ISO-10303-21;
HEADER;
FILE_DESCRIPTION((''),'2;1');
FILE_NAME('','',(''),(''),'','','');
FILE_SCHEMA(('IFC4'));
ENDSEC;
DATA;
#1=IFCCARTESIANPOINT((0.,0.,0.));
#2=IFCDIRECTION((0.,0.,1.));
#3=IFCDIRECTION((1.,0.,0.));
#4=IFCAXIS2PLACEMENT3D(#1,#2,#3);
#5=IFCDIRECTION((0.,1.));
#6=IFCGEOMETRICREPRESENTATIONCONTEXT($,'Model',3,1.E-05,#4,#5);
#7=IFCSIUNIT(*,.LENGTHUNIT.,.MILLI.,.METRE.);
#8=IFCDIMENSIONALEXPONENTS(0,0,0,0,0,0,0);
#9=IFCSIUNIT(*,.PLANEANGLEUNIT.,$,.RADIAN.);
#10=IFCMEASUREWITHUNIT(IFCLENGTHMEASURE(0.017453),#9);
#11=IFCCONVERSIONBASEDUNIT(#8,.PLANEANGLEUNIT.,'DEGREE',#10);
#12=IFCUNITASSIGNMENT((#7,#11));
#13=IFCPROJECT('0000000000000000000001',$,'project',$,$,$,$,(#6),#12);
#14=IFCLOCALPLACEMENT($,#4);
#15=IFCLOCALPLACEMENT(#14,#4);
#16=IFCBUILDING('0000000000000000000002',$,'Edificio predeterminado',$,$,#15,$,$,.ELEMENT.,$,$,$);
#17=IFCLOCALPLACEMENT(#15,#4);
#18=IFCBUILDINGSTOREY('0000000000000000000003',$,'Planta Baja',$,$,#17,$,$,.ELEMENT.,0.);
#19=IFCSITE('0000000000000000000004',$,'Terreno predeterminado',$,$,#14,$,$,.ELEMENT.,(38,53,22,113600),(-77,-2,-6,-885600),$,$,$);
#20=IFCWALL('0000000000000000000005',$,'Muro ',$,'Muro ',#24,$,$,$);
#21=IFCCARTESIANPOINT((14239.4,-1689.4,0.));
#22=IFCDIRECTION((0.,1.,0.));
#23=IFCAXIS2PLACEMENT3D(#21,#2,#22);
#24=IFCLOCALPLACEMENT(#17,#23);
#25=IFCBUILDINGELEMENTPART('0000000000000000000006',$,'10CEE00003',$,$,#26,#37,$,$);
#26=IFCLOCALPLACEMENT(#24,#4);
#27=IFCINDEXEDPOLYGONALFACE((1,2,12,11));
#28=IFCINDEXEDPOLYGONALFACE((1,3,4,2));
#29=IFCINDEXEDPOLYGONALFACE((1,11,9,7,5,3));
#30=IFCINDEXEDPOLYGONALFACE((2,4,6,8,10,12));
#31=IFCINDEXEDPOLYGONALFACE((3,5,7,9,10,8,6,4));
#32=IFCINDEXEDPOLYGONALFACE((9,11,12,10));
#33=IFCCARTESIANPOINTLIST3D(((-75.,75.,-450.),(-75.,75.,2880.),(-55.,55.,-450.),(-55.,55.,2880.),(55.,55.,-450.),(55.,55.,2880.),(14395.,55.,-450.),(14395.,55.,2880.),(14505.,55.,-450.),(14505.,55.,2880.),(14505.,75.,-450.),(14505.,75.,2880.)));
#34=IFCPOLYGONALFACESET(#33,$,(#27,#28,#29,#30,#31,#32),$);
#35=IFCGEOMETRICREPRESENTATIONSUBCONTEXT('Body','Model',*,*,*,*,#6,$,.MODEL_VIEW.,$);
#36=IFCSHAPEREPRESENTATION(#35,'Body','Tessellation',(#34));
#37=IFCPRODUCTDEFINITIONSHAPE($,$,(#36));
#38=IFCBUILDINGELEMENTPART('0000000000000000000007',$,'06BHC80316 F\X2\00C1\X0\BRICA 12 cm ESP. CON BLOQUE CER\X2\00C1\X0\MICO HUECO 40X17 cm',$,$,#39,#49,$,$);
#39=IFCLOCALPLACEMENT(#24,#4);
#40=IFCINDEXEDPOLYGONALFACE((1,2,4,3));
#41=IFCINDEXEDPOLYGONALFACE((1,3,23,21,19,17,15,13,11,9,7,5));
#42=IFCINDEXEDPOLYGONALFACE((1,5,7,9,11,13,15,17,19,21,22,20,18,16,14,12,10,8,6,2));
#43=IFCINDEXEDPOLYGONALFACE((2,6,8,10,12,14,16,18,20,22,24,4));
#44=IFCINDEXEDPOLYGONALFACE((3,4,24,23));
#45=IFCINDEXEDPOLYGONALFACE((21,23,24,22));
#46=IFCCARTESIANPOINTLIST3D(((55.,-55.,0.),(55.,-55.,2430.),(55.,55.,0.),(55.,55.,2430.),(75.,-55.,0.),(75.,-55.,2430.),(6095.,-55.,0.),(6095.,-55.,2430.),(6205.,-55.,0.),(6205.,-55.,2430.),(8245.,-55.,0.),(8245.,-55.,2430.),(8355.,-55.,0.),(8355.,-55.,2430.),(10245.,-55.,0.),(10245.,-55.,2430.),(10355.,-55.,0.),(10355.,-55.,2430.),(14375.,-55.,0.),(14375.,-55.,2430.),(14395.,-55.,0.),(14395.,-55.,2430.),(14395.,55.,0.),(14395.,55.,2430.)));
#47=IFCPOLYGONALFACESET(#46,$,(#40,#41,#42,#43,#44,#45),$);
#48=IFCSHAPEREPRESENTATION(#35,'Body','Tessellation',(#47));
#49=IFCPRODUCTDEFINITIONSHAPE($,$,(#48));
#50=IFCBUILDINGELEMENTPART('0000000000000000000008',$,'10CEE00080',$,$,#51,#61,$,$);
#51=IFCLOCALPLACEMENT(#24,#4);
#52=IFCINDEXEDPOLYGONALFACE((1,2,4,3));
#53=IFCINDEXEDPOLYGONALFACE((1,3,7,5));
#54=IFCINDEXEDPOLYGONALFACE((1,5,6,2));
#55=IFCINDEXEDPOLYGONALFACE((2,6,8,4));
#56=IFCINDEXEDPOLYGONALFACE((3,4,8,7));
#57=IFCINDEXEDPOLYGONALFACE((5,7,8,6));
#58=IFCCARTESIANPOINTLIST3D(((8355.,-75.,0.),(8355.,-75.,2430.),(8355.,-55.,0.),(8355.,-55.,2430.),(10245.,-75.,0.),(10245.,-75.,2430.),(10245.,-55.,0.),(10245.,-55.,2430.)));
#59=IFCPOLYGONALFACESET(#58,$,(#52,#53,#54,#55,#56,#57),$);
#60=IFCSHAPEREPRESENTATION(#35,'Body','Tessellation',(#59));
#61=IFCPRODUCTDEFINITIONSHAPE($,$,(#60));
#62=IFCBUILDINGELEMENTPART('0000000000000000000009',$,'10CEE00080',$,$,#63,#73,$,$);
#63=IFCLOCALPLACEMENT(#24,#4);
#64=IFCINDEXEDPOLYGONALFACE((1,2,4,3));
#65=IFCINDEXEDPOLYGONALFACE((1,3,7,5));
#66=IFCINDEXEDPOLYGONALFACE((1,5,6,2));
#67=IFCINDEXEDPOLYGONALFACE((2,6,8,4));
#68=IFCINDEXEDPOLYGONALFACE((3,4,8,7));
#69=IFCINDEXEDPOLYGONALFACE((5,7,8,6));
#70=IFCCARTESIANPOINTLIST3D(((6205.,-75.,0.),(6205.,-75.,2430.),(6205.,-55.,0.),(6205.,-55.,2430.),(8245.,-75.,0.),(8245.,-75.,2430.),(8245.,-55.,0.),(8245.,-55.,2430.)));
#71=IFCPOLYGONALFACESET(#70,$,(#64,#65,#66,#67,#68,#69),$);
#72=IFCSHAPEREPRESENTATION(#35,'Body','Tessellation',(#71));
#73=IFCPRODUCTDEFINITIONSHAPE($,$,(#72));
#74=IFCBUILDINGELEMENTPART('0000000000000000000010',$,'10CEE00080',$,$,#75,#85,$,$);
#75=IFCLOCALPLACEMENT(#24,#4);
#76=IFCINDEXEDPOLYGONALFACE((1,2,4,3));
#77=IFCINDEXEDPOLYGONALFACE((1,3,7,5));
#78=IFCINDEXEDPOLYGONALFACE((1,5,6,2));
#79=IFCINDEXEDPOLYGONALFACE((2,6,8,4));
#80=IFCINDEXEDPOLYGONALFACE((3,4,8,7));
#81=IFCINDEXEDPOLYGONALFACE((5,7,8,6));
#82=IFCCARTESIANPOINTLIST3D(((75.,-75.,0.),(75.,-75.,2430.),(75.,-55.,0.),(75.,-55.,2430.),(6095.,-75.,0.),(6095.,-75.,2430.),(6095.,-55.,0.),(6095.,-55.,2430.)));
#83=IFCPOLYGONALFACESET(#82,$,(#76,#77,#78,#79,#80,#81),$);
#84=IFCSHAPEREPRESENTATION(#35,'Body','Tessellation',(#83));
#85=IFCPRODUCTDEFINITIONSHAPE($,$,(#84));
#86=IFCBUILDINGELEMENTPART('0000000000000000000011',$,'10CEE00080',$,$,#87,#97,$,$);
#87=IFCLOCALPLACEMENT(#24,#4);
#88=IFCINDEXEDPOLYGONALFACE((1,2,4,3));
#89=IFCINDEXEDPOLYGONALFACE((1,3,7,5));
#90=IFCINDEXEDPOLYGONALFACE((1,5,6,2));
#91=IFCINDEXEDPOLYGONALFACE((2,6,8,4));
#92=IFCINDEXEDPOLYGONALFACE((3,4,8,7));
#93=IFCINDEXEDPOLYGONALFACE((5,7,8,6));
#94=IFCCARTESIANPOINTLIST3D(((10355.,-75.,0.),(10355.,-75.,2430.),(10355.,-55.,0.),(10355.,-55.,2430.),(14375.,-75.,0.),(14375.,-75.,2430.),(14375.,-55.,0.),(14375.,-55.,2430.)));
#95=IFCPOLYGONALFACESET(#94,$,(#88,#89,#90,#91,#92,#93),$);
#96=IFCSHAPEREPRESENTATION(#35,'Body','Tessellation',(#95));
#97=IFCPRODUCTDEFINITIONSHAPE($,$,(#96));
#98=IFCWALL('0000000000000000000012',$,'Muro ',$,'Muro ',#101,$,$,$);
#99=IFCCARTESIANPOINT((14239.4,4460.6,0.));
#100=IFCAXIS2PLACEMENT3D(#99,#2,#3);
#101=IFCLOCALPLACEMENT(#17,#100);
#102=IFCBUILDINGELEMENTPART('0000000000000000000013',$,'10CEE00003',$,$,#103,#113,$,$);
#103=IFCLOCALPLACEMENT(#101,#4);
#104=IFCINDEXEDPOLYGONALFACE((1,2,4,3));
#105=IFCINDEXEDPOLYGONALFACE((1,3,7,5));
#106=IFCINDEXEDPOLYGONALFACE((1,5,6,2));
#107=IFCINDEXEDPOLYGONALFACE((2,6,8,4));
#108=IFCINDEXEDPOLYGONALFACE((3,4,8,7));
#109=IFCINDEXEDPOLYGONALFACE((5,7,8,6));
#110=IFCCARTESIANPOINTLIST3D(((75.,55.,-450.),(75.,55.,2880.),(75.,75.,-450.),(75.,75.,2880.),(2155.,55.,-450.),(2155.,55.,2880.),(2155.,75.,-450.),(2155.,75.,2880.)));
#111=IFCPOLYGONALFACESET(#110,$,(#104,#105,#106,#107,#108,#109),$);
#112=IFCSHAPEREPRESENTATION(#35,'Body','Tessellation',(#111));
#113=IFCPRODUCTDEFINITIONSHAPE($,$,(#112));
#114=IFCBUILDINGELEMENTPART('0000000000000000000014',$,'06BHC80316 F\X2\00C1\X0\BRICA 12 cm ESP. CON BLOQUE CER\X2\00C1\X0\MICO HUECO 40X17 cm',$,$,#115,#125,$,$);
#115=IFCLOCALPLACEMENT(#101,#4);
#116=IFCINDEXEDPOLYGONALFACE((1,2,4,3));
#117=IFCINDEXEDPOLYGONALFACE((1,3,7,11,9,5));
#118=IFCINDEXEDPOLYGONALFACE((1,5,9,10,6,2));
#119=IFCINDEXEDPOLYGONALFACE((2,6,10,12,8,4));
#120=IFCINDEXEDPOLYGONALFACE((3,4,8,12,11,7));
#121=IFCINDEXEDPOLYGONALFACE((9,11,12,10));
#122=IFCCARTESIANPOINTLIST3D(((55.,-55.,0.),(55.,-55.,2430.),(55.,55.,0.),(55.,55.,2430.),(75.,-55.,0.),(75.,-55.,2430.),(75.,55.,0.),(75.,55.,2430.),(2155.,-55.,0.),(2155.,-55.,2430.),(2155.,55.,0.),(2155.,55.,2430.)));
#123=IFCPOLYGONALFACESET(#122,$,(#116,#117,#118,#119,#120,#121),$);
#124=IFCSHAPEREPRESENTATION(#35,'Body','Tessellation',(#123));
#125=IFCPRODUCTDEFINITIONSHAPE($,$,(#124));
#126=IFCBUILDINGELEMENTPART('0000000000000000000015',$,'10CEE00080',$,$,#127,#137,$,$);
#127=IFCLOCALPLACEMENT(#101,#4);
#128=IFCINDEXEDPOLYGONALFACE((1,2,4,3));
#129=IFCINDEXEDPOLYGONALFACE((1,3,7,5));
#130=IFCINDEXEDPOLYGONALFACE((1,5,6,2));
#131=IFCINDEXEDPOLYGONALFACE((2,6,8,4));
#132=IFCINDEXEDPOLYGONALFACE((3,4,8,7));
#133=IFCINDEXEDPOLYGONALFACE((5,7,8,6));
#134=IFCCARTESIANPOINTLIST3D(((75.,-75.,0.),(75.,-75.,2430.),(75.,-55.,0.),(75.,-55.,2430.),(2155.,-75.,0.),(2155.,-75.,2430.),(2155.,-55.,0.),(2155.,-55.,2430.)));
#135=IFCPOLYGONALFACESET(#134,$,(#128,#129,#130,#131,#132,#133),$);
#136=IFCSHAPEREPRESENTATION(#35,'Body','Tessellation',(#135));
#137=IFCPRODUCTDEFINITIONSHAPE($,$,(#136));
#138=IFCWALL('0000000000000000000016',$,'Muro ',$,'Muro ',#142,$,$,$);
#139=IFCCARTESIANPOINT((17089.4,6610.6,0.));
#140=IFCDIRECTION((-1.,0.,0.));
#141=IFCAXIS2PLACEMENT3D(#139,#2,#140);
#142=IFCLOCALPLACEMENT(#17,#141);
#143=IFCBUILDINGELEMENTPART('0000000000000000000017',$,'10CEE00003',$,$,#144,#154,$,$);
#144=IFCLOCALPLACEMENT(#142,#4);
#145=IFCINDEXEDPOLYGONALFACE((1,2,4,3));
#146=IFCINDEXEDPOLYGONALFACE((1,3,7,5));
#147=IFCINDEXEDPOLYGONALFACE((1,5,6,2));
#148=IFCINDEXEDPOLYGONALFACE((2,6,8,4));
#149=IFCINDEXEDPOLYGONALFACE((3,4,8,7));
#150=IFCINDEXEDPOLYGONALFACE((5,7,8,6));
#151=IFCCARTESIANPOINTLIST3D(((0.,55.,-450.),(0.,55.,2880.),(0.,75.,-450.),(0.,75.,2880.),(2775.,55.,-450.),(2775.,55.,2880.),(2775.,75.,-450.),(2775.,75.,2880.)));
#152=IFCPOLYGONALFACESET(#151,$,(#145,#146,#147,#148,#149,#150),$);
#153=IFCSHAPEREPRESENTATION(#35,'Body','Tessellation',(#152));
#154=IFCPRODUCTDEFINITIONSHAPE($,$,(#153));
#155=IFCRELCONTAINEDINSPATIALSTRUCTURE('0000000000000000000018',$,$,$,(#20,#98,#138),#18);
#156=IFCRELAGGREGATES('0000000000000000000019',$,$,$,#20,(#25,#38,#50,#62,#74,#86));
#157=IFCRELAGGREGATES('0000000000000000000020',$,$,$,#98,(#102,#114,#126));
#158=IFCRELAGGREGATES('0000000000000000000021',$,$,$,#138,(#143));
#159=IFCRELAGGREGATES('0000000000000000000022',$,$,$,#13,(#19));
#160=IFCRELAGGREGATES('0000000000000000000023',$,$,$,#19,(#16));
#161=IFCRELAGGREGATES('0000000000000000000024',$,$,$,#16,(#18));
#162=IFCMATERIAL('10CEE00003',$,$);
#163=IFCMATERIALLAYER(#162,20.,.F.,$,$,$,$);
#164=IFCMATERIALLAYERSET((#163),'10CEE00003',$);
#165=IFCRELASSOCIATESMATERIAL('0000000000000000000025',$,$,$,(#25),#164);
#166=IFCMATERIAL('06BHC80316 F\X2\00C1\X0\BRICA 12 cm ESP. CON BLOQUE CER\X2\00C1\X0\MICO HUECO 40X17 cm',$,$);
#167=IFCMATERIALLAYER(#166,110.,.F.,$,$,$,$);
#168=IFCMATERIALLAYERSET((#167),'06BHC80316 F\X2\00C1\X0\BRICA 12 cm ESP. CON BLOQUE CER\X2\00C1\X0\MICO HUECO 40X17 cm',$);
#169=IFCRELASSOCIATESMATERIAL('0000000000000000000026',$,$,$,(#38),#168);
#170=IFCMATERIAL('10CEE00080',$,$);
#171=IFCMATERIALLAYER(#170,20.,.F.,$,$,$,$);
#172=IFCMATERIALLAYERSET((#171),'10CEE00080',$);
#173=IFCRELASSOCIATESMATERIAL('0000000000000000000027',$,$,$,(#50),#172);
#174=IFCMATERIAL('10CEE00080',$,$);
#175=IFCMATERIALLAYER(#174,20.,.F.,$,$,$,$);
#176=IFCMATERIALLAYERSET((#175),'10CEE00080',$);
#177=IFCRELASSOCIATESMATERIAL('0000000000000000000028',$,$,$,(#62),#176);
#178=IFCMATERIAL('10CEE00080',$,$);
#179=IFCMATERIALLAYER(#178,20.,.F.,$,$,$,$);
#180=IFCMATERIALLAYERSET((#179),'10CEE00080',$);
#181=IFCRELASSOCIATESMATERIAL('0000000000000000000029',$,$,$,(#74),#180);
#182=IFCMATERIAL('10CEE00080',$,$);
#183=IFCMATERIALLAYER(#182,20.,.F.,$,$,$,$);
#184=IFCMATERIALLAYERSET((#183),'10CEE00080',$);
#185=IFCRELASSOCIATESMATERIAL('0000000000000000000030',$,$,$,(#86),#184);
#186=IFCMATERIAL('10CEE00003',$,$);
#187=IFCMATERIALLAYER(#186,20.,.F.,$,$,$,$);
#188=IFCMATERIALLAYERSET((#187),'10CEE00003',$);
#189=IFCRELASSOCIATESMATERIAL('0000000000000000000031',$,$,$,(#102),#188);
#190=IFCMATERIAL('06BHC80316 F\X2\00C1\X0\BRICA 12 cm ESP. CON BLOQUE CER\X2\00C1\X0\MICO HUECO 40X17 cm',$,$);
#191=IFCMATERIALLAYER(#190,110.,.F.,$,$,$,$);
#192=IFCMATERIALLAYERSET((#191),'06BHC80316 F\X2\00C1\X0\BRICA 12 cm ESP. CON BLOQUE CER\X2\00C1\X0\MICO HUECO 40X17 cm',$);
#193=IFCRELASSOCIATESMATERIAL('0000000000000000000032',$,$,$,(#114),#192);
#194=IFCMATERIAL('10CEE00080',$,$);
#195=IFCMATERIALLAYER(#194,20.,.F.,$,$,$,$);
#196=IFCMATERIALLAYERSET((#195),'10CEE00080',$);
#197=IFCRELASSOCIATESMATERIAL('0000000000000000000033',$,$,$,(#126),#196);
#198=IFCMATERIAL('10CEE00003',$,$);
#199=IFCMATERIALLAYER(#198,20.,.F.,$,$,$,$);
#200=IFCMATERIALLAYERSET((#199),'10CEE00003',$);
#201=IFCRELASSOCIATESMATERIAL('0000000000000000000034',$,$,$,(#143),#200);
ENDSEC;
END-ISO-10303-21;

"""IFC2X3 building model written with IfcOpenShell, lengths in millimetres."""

from ifc_helpers import new_model, entity, si_unit, converted_unit, direction, frame, origin_with_axes, place, context, subcontext, project, spatial, polyline, outline, extrude, material, layer, layer_set, layer_usage, element, aggregate, save


model = new_model("IFC2X3")

# Units and contexts
model_context = context("Model", 3, precision=1e-05, world=origin_with_axes(), true_north=direction((0.0, 1.0)))
body_context = subcontext(model_context, "Body", "Model", "MODEL_VIEW")
ifc_project = project(units=[si_unit("LENGTHUNIT", "METRE", prefix="MILLI"), converted_unit("PLANEANGLEUNIT", "DEGREE", entity("IfcLengthMeasure", 0.017453), si_unit("PLANEANGLEUNIT", "RADIAN"), dimensions=[0, 0, 0, 0, 0, 0, 0])], contexts=[model_context])

# Site, building, storey
site_placement = place(None, origin_with_axes())
site = spatial("IfcSite", under=ifc_project, at=site_placement, Name="Terreno predeterminado", CompositionType="ELEMENT", RefLatitude=(38, 53, 22, 113600), RefLongitude=(-77, -2, -6, -885600))
building_placement = place(site_placement, origin_with_axes())
building = spatial("IfcBuilding", under=site, at=building_placement, Name="Edificio predeterminado", CompositionType="ELEMENT")
storey_placement = place(building_placement, origin_with_axes())
storey = spatial("IfcBuildingStorey", under=building, at=storey_placement, Name="Planta Baja", CompositionType="ELEMENT", Elevation=0.0)

# Walls, building element parts
wall_1_placement = place(storey_placement, frame((14239.4, -1689.4, 0.0), z_axis=(0.0, 0.0, 1.0), x_axis=(0.0, 1.0, 0.0)))
wall_1 = element("IfcWall", 1, at=wall_1_placement, inside=storey, Name="Muro ", ObjectType="Muro ")
ifc_material_1 = material(Name="10CEE00003")
ifc_layer_1 = layer(ifc_material_1, 20.0, ventilated=False)
ifc_layer_set_1 = layer_set([ifc_layer_1], Name="10CEE00003")
ifc_layer_usage_1 = layer_usage(ifc_layer_set_1, "AXIS2", "NEGATIVE", -75.0)
building_element_part_1_placement = place(wall_1_placement, origin_with_axes())
building_element_part_1 = element("IfcBuildingElementPart", 2, at=building_element_part_1_placement, material=ifc_layer_usage_1, Name="10CEE00003", context=body_context, shape_type="SweptSolid", body=[
    extrude(outline(polyline([(14505.0, 75.0), (14505.0, 55.0), (14395.0, 55.0), (55.0, 55.0), (-55.0, 55.0), (-75.0, 75.0), (14505.0, 75.0)])), frame((0.0, 0.0, -450.0), z_axis=(0.0, 0.0, 1.0), x_axis=(1.0, 0.0, 0.0)), (0.0, 0.0, 1.0), 3330.0),
])
ifc_material_2 = material(Name="06BHC80316 FÁBRICA 12 cm ESP. CON BLOQUE CERÁMICO HUECO 40X17 cm")
ifc_layer_2 = layer(ifc_material_2, 110.0, ventilated=False)
ifc_layer_set_2 = layer_set([ifc_layer_2], Name="06BHC80316 FÁBRICA 12 cm ESP. CON BLOQUE CERÁMICO HUECO 40X17 cm")
ifc_layer_usage_2 = layer_usage(ifc_layer_set_2, "AXIS2", "NEGATIVE", -55.0)
building_element_part_2_placement = place(wall_1_placement, origin_with_axes())
building_element_part_2 = element("IfcBuildingElementPart", 3, at=building_element_part_2_placement, material=ifc_layer_usage_2, Name="06BHC80316 FÁBRICA 12 cm ESP. CON BLOQUE CERÁMICO HUECO 40X17 cm", context=body_context, shape_type="SweptSolid", body=[
    extrude(outline(polyline([(14395.0, 55.0), (14395.0, -55.0), (14375.0, -55.0), (10355.0, -55.0), (10245.0, -55.0), (8355.0, -55.0), (8245.0, -55.0), (6205.0, -55.0), (6095.0, -55.0), (75.0, -55.0), (55.0, -55.0), (55.0, 55.0), (14395.0, 55.0)])), origin_with_axes(), (0.0, 0.0, 1.0), 2430.0),
])
ifc_material_3 = material(Name="10CEE00080")
ifc_layer_3 = layer(ifc_material_3, 20.0, ventilated=False)
ifc_layer_set_3 = layer_set([ifc_layer_3], Name="10CEE00080")
ifc_layer_usage_3 = layer_usage(ifc_layer_set_3, "AXIS2", "NEGATIVE", 55.0)
building_element_part_3_placement = place(wall_1_placement, origin_with_axes())
building_element_part_3 = element("IfcBuildingElementPart", 4, at=building_element_part_3_placement, material=ifc_layer_usage_3, Name="10CEE00080", context=body_context, shape_type="SweptSolid", body=[
    extrude(outline(polyline([(8355.0, -55.0), (10245.0, -55.0), (10245.0, -75.0), (8355.0, -75.0), (8355.0, -55.0)])), origin_with_axes(), (0.0, 0.0, 1.0), 2430.0),
])
ifc_material_4 = material(Name="10CEE00080")
ifc_layer_4 = layer(ifc_material_4, 20.0, ventilated=False)
ifc_layer_set_4 = layer_set([ifc_layer_4], Name="10CEE00080")
ifc_layer_usage_4 = layer_usage(ifc_layer_set_4, "AXIS2", "NEGATIVE", 55.0)
building_element_part_4_placement = place(wall_1_placement, origin_with_axes())
building_element_part_4 = element("IfcBuildingElementPart", 5, at=building_element_part_4_placement, material=ifc_layer_usage_4, Name="10CEE00080", context=body_context, shape_type="SweptSolid", body=[
    extrude(outline(polyline([(8245.0, -55.0), (8245.0, -75.0), (6205.0, -75.0), (6205.0, -55.0), (8245.0, -55.0)])), origin_with_axes(), (0.0, 0.0, 1.0), 2430.0),
])
ifc_material_5 = material(Name="10CEE00080")
ifc_layer_5 = layer(ifc_material_5, 20.0, ventilated=False)
ifc_layer_set_5 = layer_set([ifc_layer_5], Name="10CEE00080")
ifc_layer_usage_5 = layer_usage(ifc_layer_set_5, "AXIS2", "NEGATIVE", 55.0)
building_element_part_5_placement = place(wall_1_placement, origin_with_axes())
building_element_part_5 = element("IfcBuildingElementPart", 6, at=building_element_part_5_placement, material=ifc_layer_usage_5, Name="10CEE00080", context=body_context, shape_type="SweptSolid", body=[
    extrude(outline(polyline([(6095.0, -55.0), (6095.0, -75.0), (75.0, -75.0), (75.0, -55.0), (6095.0, -55.0)])), origin_with_axes(), (0.0, 0.0, 1.0), 2430.0),
])
ifc_material_6 = material(Name="10CEE00080")
ifc_layer_6 = layer(ifc_material_6, 20.0, ventilated=False)
ifc_layer_set_6 = layer_set([ifc_layer_6], Name="10CEE00080")
ifc_layer_usage_6 = layer_usage(ifc_layer_set_6, "AXIS2", "NEGATIVE", 55.0)
building_element_part_6_placement = place(wall_1_placement, origin_with_axes())
building_element_part_6 = element("IfcBuildingElementPart", 7, at=building_element_part_6_placement, material=ifc_layer_usage_6, Name="10CEE00080", context=body_context, shape_type="SweptSolid", body=[
    extrude(outline(polyline([(14375.0, -55.0), (14375.0, -75.0), (10355.0, -75.0), (10355.0, -55.0), (14375.0, -55.0)])), origin_with_axes(), (0.0, 0.0, 1.0), 2430.0),
])
aggregate(wall_1, [building_element_part_1, building_element_part_2, building_element_part_3, building_element_part_4, building_element_part_5, building_element_part_6])
wall_2_placement = place(storey_placement, frame((14239.4, 4460.6, 0.0), z_axis=(0.0, 0.0, 1.0), x_axis=(1.0, 0.0, 0.0)))
wall_2 = element("IfcWall", 8, at=wall_2_placement, inside=storey, Name="Muro ", ObjectType="Muro ")
ifc_material_7 = material(Name="10CEE00003")
ifc_layer_7 = layer(ifc_material_7, 20.0, ventilated=False)
ifc_layer_set_7 = layer_set([ifc_layer_7], Name="10CEE00003")
ifc_layer_usage_7 = layer_usage(ifc_layer_set_7, "AXIS2", "NEGATIVE", -75.0)
building_element_part_7_placement = place(wall_2_placement, origin_with_axes())
building_element_part_7 = element("IfcBuildingElementPart", 9, at=building_element_part_7_placement, material=ifc_layer_usage_7, Name="10CEE00003", context=body_context, shape_type="SweptSolid", body=[
    extrude(outline(polyline([(2155.0, 75.0), (2155.0, 55.0), (75.0, 55.0), (75.0, 75.0), (2155.0, 75.0)])), frame((0.0, 0.0, -450.0), z_axis=(0.0, 0.0, 1.0), x_axis=(1.0, 0.0, 0.0)), (0.0, 0.0, 1.0), 3330.0),
])
ifc_material_8 = material(Name="06BHC80316 FÁBRICA 12 cm ESP. CON BLOQUE CERÁMICO HUECO 40X17 cm")
ifc_layer_8 = layer(ifc_material_8, 110.0, ventilated=False)
ifc_layer_set_8 = layer_set([ifc_layer_8], Name="06BHC80316 FÁBRICA 12 cm ESP. CON BLOQUE CERÁMICO HUECO 40X17 cm")
ifc_layer_usage_8 = layer_usage(ifc_layer_set_8, "AXIS2", "NEGATIVE", -55.0)
building_element_part_8_placement = place(wall_2_placement, origin_with_axes())
building_element_part_8 = element("IfcBuildingElementPart", 10, at=building_element_part_8_placement, material=ifc_layer_usage_8, Name="06BHC80316 FÁBRICA 12 cm ESP. CON BLOQUE CERÁMICO HUECO 40X17 cm", context=body_context, shape_type="SweptSolid", body=[
    extrude(outline(polyline([(2155.0, 55.0), (2155.0, -55.0), (75.0, -55.0), (55.0, -55.0), (55.0, 55.0), (75.0, 55.0), (2155.0, 55.0)])), origin_with_axes(), (0.0, 0.0, 1.0), 2430.0),
])
ifc_material_9 = material(Name="10CEE00080")
ifc_layer_9 = layer(ifc_material_9, 20.0, ventilated=False)
ifc_layer_set_9 = layer_set([ifc_layer_9], Name="10CEE00080")
ifc_layer_usage_9 = layer_usage(ifc_layer_set_9, "AXIS2", "NEGATIVE", 55.0)
building_element_part_9_placement = place(wall_2_placement, origin_with_axes())
building_element_part_9 = element("IfcBuildingElementPart", 11, at=building_element_part_9_placement, material=ifc_layer_usage_9, Name="10CEE00080", context=body_context, shape_type="SweptSolid", body=[
    extrude(outline(polyline([(2155.0, -55.0), (2155.0, -75.0), (75.0, -75.0), (75.0, -55.0), (2155.0, -55.0)])), origin_with_axes(), (0.0, 0.0, 1.0), 2430.0),
])
aggregate(wall_2, [building_element_part_7, building_element_part_8, building_element_part_9])

# Wall, building element part
wall_3_placement = place(storey_placement, frame((17089.4, 6610.6, 0.0), z_axis=(0.0, 0.0, 1.0), x_axis=(-1.0, 0.0, 0.0)))
wall_3 = element("IfcWall", 12, at=wall_3_placement, inside=storey, Name="Muro ", ObjectType="Muro ")
ifc_material_10 = material(Name="10CEE00003")
ifc_layer_10 = layer(ifc_material_10, 20.0, ventilated=False)
ifc_layer_set_10 = layer_set([ifc_layer_10], Name="10CEE00003")
ifc_layer_usage_10 = layer_usage(ifc_layer_set_10, "AXIS2", "NEGATIVE", -75.0)
building_element_part_10_placement = place(wall_3_placement, origin_with_axes())
building_element_part_10 = element("IfcBuildingElementPart", 13, at=building_element_part_10_placement, material=ifc_layer_usage_10, Name="10CEE00003", context=body_context, shape_type="SweptSolid", body=[
    extrude(outline(polyline([(0.0, 75.0), (2775.0, 75.0), (2775.0, 55.0), (0.0, 55.0), (0.0, 75.0)])), frame((0.0, 0.0, -450.0), z_axis=(0.0, 0.0, 1.0), x_axis=(1.0, 0.0, 0.0)), (0.0, 0.0, 1.0), 3330.0),
])
aggregate(wall_3, [building_element_part_10])

save(model, "model.ifc")
